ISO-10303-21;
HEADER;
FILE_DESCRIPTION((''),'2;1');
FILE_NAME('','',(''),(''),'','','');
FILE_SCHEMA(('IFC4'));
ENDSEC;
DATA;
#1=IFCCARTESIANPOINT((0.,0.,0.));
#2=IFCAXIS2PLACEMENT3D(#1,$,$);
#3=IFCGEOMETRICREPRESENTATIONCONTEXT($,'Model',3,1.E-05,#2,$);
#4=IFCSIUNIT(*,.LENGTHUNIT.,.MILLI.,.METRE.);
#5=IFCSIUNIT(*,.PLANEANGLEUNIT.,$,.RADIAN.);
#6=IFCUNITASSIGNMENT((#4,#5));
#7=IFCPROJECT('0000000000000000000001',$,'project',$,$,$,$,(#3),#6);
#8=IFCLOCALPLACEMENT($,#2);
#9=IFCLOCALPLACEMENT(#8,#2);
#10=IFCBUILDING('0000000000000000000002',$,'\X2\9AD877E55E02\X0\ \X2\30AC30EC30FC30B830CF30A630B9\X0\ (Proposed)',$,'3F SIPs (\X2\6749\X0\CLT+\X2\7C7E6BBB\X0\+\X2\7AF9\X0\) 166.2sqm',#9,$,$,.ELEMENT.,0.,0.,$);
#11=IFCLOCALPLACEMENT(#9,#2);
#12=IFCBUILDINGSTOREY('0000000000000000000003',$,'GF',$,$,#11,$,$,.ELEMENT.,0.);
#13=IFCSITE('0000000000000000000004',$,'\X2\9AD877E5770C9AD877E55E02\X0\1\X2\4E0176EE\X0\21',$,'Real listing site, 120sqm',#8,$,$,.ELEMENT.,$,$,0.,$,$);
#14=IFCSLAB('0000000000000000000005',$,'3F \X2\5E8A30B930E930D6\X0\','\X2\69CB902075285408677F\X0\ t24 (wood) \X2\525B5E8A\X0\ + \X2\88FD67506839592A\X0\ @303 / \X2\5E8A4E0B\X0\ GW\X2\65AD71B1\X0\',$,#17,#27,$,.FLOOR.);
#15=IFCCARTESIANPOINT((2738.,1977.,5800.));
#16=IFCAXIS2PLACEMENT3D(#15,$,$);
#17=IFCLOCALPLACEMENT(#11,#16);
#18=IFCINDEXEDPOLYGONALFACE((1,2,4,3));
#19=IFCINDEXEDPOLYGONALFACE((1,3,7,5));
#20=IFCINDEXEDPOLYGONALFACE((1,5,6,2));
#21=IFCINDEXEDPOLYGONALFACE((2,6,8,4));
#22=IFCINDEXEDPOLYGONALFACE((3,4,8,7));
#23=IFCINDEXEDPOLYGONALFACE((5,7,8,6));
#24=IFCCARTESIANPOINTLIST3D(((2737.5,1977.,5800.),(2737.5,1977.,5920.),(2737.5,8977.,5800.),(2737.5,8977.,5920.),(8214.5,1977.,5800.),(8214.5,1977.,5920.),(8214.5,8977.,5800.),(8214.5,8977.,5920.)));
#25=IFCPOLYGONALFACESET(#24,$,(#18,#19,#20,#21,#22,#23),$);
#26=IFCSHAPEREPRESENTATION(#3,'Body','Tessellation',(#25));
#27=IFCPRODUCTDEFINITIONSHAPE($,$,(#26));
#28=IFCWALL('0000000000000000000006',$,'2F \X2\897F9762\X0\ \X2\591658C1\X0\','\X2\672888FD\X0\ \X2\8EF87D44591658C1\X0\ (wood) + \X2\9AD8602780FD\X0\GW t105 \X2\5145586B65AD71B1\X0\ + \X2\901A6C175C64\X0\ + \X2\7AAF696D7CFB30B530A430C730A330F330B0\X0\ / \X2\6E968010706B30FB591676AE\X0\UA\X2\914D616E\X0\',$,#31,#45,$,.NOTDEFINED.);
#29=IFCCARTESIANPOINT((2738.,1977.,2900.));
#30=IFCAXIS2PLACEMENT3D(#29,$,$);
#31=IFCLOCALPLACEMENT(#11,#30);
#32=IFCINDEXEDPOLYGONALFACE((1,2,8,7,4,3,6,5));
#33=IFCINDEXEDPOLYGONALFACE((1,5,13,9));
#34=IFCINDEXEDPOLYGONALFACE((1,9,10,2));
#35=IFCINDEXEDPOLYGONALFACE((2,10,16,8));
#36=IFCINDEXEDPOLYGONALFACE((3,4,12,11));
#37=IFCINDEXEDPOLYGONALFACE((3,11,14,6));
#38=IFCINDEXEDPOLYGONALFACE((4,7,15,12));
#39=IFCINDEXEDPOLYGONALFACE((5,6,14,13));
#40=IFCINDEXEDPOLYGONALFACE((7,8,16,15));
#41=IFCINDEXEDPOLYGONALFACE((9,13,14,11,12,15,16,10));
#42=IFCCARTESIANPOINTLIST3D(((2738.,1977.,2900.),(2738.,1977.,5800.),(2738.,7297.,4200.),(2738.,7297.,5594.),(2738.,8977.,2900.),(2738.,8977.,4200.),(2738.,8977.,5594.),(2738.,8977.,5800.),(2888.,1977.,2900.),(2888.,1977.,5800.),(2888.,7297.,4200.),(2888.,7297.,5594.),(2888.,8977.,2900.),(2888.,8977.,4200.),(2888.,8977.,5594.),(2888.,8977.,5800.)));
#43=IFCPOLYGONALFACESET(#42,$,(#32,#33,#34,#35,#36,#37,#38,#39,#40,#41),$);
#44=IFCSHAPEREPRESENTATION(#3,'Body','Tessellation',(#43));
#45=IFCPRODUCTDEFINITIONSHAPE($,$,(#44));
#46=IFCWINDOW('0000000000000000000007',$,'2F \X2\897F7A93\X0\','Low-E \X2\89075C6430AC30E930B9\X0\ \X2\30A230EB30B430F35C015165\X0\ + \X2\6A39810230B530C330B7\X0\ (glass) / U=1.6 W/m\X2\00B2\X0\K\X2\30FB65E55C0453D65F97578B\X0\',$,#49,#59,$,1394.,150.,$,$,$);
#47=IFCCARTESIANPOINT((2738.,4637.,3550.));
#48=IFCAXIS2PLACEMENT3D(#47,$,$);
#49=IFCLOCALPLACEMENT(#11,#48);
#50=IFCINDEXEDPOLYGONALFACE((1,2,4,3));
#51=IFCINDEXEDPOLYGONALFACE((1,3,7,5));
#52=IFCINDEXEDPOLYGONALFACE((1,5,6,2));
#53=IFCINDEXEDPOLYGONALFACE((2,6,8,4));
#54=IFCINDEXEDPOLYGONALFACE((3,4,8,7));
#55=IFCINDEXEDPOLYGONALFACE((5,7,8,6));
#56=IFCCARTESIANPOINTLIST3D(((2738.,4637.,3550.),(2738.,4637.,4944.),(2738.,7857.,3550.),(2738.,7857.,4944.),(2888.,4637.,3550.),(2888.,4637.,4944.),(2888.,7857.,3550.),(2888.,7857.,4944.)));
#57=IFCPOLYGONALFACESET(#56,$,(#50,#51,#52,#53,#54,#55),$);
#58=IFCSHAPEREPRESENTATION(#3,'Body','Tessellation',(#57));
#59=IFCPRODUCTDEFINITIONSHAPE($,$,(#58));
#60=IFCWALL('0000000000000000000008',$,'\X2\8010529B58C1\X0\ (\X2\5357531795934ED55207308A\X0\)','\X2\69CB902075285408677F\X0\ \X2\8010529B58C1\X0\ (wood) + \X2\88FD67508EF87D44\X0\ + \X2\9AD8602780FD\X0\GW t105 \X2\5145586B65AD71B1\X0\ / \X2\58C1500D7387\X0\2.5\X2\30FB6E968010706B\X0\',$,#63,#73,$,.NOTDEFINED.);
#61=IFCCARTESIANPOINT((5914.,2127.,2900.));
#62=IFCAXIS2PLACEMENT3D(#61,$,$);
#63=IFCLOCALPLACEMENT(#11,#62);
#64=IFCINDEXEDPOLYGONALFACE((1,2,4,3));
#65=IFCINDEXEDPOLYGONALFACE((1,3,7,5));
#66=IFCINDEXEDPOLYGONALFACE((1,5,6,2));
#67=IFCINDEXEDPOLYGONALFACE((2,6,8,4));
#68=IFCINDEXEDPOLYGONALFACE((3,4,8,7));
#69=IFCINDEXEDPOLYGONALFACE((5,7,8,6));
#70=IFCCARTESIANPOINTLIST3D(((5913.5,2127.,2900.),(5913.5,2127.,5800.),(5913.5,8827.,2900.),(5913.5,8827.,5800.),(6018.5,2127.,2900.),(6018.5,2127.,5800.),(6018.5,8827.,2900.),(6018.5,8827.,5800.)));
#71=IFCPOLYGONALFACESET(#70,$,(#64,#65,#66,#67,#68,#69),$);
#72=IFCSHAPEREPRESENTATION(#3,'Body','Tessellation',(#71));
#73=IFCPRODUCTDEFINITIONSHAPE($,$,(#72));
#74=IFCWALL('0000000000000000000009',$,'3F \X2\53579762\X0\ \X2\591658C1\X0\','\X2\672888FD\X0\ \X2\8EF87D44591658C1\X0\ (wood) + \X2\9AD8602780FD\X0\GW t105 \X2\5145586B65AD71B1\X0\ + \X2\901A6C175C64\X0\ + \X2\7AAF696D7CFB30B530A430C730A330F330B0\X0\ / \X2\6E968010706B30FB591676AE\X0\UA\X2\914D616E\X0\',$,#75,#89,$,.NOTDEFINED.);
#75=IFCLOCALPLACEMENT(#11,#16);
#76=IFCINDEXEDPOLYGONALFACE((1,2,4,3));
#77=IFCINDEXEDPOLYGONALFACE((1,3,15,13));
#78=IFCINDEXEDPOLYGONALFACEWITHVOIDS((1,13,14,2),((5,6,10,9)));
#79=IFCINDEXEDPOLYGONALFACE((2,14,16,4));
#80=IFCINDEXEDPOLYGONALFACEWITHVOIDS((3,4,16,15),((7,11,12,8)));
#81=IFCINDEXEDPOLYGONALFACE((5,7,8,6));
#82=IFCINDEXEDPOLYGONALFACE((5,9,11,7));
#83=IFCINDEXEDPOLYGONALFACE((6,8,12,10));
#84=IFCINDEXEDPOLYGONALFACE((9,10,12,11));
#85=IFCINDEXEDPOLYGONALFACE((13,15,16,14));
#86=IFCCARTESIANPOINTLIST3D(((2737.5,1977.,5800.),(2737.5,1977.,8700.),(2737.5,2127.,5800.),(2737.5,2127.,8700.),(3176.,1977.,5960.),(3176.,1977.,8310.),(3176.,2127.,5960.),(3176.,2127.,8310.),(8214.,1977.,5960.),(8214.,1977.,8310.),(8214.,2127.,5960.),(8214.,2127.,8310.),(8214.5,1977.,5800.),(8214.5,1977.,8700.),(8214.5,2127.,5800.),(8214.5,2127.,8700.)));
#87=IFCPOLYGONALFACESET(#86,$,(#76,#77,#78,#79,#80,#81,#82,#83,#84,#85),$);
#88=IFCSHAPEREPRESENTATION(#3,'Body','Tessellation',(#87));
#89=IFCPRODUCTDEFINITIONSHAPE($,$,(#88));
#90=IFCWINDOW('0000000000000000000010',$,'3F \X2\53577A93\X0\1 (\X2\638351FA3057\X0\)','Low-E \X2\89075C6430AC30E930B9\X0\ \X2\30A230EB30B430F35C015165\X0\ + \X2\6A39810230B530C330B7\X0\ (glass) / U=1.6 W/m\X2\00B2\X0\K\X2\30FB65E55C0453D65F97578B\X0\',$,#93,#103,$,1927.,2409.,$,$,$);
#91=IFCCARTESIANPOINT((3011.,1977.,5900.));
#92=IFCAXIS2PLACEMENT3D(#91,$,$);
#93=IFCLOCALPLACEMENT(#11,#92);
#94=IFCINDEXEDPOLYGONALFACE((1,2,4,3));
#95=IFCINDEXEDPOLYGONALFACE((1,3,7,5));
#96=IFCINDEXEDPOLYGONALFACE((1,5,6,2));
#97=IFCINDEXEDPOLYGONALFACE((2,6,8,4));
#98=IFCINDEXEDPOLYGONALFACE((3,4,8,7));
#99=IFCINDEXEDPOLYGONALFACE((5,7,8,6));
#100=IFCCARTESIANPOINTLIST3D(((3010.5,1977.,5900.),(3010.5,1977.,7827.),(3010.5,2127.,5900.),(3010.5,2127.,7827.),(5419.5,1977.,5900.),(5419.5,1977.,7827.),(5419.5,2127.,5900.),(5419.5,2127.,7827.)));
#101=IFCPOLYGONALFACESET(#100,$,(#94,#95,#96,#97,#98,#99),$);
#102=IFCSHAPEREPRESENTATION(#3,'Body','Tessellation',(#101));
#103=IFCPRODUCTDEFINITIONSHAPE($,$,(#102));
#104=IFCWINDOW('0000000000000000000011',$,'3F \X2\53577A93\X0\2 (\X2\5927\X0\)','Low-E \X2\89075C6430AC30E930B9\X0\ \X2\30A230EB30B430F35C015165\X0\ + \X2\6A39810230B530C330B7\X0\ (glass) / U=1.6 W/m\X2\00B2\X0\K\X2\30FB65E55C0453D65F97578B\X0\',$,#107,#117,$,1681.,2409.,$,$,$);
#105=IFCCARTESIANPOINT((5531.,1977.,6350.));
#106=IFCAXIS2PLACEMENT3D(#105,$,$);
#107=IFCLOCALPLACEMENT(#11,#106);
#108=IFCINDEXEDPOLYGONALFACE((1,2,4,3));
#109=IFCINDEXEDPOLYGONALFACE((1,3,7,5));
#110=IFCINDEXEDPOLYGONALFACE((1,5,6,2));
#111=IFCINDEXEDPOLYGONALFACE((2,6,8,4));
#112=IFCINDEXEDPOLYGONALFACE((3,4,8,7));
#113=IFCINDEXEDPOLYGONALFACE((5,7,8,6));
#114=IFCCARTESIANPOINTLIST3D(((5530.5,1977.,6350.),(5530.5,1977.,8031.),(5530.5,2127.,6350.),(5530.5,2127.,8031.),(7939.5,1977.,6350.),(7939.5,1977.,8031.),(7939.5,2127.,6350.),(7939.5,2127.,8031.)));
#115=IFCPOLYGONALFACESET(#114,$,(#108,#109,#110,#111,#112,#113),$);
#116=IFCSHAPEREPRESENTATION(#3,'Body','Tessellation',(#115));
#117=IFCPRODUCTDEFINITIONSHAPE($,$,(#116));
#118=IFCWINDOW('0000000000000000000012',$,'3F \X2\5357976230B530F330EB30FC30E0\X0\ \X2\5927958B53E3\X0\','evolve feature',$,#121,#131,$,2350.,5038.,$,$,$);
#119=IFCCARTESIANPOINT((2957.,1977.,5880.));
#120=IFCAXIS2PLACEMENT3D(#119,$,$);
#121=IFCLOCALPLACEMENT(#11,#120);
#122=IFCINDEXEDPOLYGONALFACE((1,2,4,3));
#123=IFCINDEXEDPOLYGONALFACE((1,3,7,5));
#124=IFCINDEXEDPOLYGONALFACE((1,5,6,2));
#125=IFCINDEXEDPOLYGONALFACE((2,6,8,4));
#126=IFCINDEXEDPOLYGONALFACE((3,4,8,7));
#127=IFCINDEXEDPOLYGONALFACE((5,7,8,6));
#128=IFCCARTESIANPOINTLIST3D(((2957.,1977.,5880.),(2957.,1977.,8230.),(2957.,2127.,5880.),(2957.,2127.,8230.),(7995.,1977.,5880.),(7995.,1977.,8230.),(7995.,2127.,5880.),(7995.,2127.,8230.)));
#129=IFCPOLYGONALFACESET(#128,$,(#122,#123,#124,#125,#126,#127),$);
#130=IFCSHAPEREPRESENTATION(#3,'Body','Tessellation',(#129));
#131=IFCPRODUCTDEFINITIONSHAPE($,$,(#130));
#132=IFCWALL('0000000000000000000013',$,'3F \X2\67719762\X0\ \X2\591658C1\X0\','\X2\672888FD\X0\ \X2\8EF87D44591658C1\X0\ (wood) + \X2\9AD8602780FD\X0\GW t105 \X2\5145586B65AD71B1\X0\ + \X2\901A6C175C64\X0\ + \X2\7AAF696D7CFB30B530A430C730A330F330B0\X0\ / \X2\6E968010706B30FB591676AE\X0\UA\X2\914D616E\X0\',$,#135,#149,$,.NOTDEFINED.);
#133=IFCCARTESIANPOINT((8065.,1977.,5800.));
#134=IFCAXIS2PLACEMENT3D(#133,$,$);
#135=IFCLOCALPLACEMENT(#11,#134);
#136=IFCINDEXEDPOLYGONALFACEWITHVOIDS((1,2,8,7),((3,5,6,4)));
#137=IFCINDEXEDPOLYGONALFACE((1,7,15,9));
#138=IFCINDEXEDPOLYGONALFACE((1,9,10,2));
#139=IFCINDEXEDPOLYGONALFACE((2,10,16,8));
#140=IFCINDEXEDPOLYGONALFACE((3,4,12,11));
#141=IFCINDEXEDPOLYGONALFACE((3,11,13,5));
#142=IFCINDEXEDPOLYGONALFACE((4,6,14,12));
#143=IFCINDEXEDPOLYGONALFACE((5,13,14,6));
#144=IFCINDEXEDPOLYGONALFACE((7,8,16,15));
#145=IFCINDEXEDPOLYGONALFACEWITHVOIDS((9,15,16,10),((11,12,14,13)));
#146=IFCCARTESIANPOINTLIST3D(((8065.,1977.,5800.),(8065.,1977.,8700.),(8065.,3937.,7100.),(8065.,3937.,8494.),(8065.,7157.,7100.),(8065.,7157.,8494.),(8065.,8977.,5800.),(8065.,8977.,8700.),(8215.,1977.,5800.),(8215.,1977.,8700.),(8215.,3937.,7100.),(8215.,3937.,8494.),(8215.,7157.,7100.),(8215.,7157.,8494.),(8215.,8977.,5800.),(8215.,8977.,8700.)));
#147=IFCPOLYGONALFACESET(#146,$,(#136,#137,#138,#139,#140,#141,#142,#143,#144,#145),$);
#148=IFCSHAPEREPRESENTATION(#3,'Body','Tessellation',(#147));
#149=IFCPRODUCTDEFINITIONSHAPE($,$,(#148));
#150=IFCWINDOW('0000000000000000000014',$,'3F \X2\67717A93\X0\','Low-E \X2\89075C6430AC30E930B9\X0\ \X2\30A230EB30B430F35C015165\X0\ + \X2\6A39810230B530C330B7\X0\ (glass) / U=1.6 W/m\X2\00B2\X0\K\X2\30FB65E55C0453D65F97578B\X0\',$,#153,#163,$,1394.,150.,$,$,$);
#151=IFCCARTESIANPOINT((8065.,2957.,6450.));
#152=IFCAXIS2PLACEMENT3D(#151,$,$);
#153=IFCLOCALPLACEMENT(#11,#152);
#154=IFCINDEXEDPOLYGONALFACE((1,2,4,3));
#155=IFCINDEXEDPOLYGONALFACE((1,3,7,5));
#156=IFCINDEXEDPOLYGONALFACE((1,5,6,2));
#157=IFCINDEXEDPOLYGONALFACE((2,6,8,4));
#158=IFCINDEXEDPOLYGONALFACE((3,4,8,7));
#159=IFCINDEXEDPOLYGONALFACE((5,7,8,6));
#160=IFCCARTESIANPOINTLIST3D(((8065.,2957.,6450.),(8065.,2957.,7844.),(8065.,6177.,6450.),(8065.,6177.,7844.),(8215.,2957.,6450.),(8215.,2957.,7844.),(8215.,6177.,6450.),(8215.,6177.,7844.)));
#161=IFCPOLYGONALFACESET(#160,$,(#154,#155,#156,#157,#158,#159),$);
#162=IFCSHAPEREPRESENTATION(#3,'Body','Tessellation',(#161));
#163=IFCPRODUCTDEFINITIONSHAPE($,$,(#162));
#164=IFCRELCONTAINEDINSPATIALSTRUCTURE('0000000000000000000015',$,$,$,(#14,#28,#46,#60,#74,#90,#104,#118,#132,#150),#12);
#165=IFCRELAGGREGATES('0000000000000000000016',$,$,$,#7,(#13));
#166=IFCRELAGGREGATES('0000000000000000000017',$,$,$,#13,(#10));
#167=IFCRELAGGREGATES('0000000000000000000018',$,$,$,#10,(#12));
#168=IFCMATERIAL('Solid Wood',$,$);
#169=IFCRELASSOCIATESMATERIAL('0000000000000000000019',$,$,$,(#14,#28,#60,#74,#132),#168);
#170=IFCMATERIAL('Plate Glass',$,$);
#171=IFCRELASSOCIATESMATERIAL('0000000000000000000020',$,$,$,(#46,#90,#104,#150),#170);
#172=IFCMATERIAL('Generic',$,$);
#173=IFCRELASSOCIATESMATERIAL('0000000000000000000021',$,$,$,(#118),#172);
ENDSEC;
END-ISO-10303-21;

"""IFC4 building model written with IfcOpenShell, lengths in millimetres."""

from ifc_helpers import new_model, si_unit, frame, frame_2d, origin, place, context, project, spatial, rectangle, extrude, material, element, fill, save


model = new_model("IFC4")

# Units and contexts
model_context = context("Model", 3, precision=1e-05, world=origin())
ifc_project = project(units=[si_unit("LENGTHUNIT", "METRE", prefix="MILLI"), si_unit("PLANEANGLEUNIT", "RADIAN")], contexts=[model_context])

# Site, building, storey
site_placement = place(None, origin())
site = spatial("IfcSite", under=ifc_project, at=site_placement, Name="高知県高知市1丁目21", ObjectType="Real listing site, 120sqm", CompositionType="ELEMENT", RefElevation=0.0)
building_placement = place(site_placement, origin())
building = spatial("IfcBuilding", under=site, at=building_placement, Name="高知市 ガレージハウス (Proposed)", ObjectType="3F SIPs (杉CLT+籾殻+竹) 166.2sqm", CompositionType="ELEMENT", ElevationOfRefHeight=0.0, ElevationOfTerrain=0.0)
storey_placement = place(building_placement, origin())
storey = spatial("IfcBuildingStorey", under=building, at=storey_placement, Name="GF", CompositionType="ELEMENT", Elevation=0.0)

# Slab
ifc_material_1 = material(Name="Solid Wood")
slab_placement = place(storey_placement, frame((2738.0, 1977.0, 5800.0)))
element("IfcSlab", 1, at=slab_placement, inside=storey, material=ifc_material_1, Name="3F 床スラブ", Description="構造用合板 t24 (wood) 剛床 + 製材根太 @303 / 床下 GW断熱", PredefinedType="FLOOR", context=model_context, shape_type="SweptSolid", body=[
    extrude(rectangle(XDim=5477.0, YDim=7000.0, at=frame_2d((2738.0, 3500.0))), frame((2738.0, 1977.0, 5800.0)), (0.0, 0.0, 1.0), 120.0),
])

# Wall, opening, window
wall_1_placement = place(storey_placement, frame((2738.0, 1977.0, 2900.0)))
wall_1 = element("IfcWall", 2, at=wall_1_placement, inside=storey, material=ifc_material_1, Name="2F 西面 外壁", Description="木製 軸組外壁 (wood) + 高性能GW t105 充填断熱 + 通気層 + 窯業系サイディング / 準耐火・外皮UA配慮", PredefinedType="NOTDEFINED", context=model_context, shape_type="SweptSolid", body=[
    extrude(rectangle(XDim=150.0, YDim=7000.0, at=frame_2d((75.0, 3500.0))), frame((2738.0, 1977.0, 2900.0)), (0.0, 0.0, 1.0), 2900.0),
])
opening_1_placement = place(storey_placement, frame((2738.0, 4637.0, 3550.0)))
opening_1 = element("IfcOpeningElement", 3, at=opening_1_placement, cuts=wall_1, PredefinedType="NOTDEFINED", context=model_context, shape_type="SweptSolid", body=[
    extrude(rectangle(XDim=150.0, YDim=3220.0, at=frame_2d((75.0, 1610.0))), frame((2738.0, 4637.0, 3550.0)), (0.0, 0.0, 1.0), 1394.0),
])
ifc_material_2 = material(Name="Plate Glass")
window_1_placement = place(storey_placement, frame((2738.0, 4637.0, 3550.0)))
window_1 = element("IfcWindow", 4, at=window_1_placement, inside=storey, material=ifc_material_2, Name="2F 西窓", Description="Low-E 複層ガラス アルゴン封入 + 樹脂サッシ (glass) / U=1.6 W/m²K・日射取得型", OverallHeight=1394.0, OverallWidth=150.0, context=model_context, shape_type="SweptSolid", body=[
    extrude(rectangle(XDim=150.0, YDim=3220.0, at=frame_2d((75.0, 1610.0))), frame((2738.0, 4637.0, 3550.0)), (0.0, 0.0, 1.0), 1394.0),
])
fill(opening_1, window_1)

# Wall
wall_2_placement = place(storey_placement, frame((5914.0, 2127.0, 2900.0)))
element("IfcWall", 5, at=wall_2_placement, inside=storey, material=ifc_material_1, Name="耐力壁 (南北間仕切り)", Description="構造用合板 耐力壁 (wood) + 製材軸組 + 高性能GW t105 充填断熱 / 壁倍率2.5・準耐火", PredefinedType="NOTDEFINED", context=model_context, shape_type="SweptSolid", body=[
    extrude(rectangle(XDim=105.0, YDim=6700.0, at=frame_2d((52.0, 3350.0))), frame((5914.0, 2127.0, 2900.0)), (0.0, 0.0, 1.0), 2900.0),
])

# Wall, openings, windows
wall_3_placement = place(storey_placement, frame((2738.0, 1977.0, 5800.0)))
wall_3 = element("IfcWall", 6, at=wall_3_placement, inside=storey, material=ifc_material_1, Name="3F 南面 外壁", Description="木製 軸組外壁 (wood) + 高性能GW t105 充填断熱 + 通気層 + 窯業系サイディング / 準耐火・外皮UA配慮", PredefinedType="NOTDEFINED", context=model_context, shape_type="SweptSolid", body=[
    extrude(rectangle(XDim=5477.0, YDim=150.0, at=frame_2d((2738.0, 75.0))), frame((2738.0, 1977.0, 5800.0)), (0.0, 0.0, 1.0), 2900.0),
])
opening_2_placement = place(storey_placement, frame((3011.0, 1977.0, 5900.0)))
opening_2 = element("IfcOpeningElement", 7, at=opening_2_placement, cuts=wall_3, PredefinedType="NOTDEFINED", context=model_context, shape_type="SweptSolid", body=[
    extrude(rectangle(XDim=2409.0, YDim=150.0, at=frame_2d((1204.0, 75.0))), frame((3011.0, 1977.0, 5900.0)), (0.0, 0.0, 1.0), 1927.0),
])
opening_3_placement = place(storey_placement, frame((5531.0, 1977.0, 6350.0)))
opening_3 = element("IfcOpeningElement", 8, at=opening_3_placement, cuts=wall_3, PredefinedType="NOTDEFINED", context=model_context, shape_type="SweptSolid", body=[
    extrude(rectangle(XDim=2409.0, YDim=150.0, at=frame_2d((1204.0, 75.0))), frame((5531.0, 1977.0, 6350.0)), (0.0, 0.0, 1.0), 1681.0),
])
opening_4_placement = place(storey_placement, frame((2957.0, 1977.0, 5880.0)))
opening_4 = element("IfcOpeningElement", 9, at=opening_4_placement, cuts=wall_3, PredefinedType="NOTDEFINED", context=model_context, shape_type="SweptSolid", body=[
    extrude(rectangle(XDim=5038.0, YDim=150.0, at=frame_2d((2519.0, 75.0))), frame((2957.0, 1977.0, 5880.0)), (0.0, 0.0, 1.0), 2350.0),
])
window_2_placement = place(storey_placement, frame((3011.0, 1977.0, 5900.0)))
window_2 = element("IfcWindow", 10, at=window_2_placement, inside=storey, material=ifc_material_2, Name="3F 南窓1 (掃出し)", Description="Low-E 複層ガラス アルゴン封入 + 樹脂サッシ (glass) / U=1.6 W/m²K・日射取得型", OverallHeight=1927.0, OverallWidth=2409.0, context=model_context, shape_type="SweptSolid", body=[
    extrude(rectangle(XDim=2409.0, YDim=150.0, at=frame_2d((1204.0, 75.0))), frame((3011.0, 1977.0, 5900.0)), (0.0, 0.0, 1.0), 1927.0),
])
fill(opening_2, window_2)
window_3_placement = place(storey_placement, frame((5531.0, 1977.0, 6350.0)))
window_3 = element("IfcWindow", 11, at=window_3_placement, inside=storey, material=ifc_material_2, Name="3F 南窓2 (大)", Description="Low-E 複層ガラス アルゴン封入 + 樹脂サッシ (glass) / U=1.6 W/m²K・日射取得型", OverallHeight=1681.0, OverallWidth=2409.0, context=model_context, shape_type="SweptSolid", body=[
    extrude(rectangle(XDim=2409.0, YDim=150.0, at=frame_2d((1204.0, 75.0))), frame((5531.0, 1977.0, 6350.0)), (0.0, 0.0, 1.0), 1681.0),
])
fill(opening_3, window_3)
ifc_material_3 = material(Name="Generic")
window_4_placement = place(storey_placement, frame((2957.0, 1977.0, 5880.0)))
window_4 = element("IfcWindow", 12, at=window_4_placement, inside=storey, material=ifc_material_3, Name="3F 南面サンルーム 大開口", Description="evolve feature", OverallHeight=2350.0, OverallWidth=5038.0, context=model_context, shape_type="SweptSolid", body=[
    extrude(rectangle(XDim=5038.0, YDim=150.0, at=frame_2d((2519.0, 75.0))), frame((2957.0, 1977.0, 5880.0)), (0.0, 0.0, 1.0), 2350.0),
])
fill(opening_4, window_4)

# Wall, opening, window
wall_4_placement = place(storey_placement, frame((8065.0, 1977.0, 5800.0)))
wall_4 = element("IfcWall", 13, at=wall_4_placement, inside=storey, material=ifc_material_1, Name="3F 東面 外壁", Description="木製 軸組外壁 (wood) + 高性能GW t105 充填断熱 + 通気層 + 窯業系サイディング / 準耐火・外皮UA配慮", PredefinedType="NOTDEFINED", context=model_context, shape_type="SweptSolid", body=[
    extrude(rectangle(XDim=150.0, YDim=7000.0, at=frame_2d((75.0, 3500.0))), frame((8065.0, 1977.0, 5800.0)), (0.0, 0.0, 1.0), 2900.0),
])
opening_5_placement = place(storey_placement, frame((8065.0, 2957.0, 6450.0)))
opening_5 = element("IfcOpeningElement", 14, at=opening_5_placement, cuts=wall_4, PredefinedType="NOTDEFINED", context=model_context, shape_type="SweptSolid", body=[
    extrude(rectangle(XDim=150.0, YDim=3220.0, at=frame_2d((75.0, 1610.0))), frame((8065.0, 2957.0, 6450.0)), (0.0, 0.0, 1.0), 1394.0),
])
window_5_placement = place(storey_placement, frame((8065.0, 2957.0, 6450.0)))
window_5 = element("IfcWindow", 15, at=window_5_placement, inside=storey, material=ifc_material_2, Name="3F 東窓", Description="Low-E 複層ガラス アルゴン封入 + 樹脂サッシ (glass) / U=1.6 W/m²K・日射取得型", OverallHeight=1394.0, OverallWidth=150.0, context=model_context, shape_type="SweptSolid", body=[
    extrude(rectangle(XDim=150.0, YDim=3220.0, at=frame_2d((75.0, 1610.0))), frame((8065.0, 2957.0, 6450.0)), (0.0, 0.0, 1.0), 1394.0),
])
fill(opening_5, window_5)

save(model, "model.ifc")
